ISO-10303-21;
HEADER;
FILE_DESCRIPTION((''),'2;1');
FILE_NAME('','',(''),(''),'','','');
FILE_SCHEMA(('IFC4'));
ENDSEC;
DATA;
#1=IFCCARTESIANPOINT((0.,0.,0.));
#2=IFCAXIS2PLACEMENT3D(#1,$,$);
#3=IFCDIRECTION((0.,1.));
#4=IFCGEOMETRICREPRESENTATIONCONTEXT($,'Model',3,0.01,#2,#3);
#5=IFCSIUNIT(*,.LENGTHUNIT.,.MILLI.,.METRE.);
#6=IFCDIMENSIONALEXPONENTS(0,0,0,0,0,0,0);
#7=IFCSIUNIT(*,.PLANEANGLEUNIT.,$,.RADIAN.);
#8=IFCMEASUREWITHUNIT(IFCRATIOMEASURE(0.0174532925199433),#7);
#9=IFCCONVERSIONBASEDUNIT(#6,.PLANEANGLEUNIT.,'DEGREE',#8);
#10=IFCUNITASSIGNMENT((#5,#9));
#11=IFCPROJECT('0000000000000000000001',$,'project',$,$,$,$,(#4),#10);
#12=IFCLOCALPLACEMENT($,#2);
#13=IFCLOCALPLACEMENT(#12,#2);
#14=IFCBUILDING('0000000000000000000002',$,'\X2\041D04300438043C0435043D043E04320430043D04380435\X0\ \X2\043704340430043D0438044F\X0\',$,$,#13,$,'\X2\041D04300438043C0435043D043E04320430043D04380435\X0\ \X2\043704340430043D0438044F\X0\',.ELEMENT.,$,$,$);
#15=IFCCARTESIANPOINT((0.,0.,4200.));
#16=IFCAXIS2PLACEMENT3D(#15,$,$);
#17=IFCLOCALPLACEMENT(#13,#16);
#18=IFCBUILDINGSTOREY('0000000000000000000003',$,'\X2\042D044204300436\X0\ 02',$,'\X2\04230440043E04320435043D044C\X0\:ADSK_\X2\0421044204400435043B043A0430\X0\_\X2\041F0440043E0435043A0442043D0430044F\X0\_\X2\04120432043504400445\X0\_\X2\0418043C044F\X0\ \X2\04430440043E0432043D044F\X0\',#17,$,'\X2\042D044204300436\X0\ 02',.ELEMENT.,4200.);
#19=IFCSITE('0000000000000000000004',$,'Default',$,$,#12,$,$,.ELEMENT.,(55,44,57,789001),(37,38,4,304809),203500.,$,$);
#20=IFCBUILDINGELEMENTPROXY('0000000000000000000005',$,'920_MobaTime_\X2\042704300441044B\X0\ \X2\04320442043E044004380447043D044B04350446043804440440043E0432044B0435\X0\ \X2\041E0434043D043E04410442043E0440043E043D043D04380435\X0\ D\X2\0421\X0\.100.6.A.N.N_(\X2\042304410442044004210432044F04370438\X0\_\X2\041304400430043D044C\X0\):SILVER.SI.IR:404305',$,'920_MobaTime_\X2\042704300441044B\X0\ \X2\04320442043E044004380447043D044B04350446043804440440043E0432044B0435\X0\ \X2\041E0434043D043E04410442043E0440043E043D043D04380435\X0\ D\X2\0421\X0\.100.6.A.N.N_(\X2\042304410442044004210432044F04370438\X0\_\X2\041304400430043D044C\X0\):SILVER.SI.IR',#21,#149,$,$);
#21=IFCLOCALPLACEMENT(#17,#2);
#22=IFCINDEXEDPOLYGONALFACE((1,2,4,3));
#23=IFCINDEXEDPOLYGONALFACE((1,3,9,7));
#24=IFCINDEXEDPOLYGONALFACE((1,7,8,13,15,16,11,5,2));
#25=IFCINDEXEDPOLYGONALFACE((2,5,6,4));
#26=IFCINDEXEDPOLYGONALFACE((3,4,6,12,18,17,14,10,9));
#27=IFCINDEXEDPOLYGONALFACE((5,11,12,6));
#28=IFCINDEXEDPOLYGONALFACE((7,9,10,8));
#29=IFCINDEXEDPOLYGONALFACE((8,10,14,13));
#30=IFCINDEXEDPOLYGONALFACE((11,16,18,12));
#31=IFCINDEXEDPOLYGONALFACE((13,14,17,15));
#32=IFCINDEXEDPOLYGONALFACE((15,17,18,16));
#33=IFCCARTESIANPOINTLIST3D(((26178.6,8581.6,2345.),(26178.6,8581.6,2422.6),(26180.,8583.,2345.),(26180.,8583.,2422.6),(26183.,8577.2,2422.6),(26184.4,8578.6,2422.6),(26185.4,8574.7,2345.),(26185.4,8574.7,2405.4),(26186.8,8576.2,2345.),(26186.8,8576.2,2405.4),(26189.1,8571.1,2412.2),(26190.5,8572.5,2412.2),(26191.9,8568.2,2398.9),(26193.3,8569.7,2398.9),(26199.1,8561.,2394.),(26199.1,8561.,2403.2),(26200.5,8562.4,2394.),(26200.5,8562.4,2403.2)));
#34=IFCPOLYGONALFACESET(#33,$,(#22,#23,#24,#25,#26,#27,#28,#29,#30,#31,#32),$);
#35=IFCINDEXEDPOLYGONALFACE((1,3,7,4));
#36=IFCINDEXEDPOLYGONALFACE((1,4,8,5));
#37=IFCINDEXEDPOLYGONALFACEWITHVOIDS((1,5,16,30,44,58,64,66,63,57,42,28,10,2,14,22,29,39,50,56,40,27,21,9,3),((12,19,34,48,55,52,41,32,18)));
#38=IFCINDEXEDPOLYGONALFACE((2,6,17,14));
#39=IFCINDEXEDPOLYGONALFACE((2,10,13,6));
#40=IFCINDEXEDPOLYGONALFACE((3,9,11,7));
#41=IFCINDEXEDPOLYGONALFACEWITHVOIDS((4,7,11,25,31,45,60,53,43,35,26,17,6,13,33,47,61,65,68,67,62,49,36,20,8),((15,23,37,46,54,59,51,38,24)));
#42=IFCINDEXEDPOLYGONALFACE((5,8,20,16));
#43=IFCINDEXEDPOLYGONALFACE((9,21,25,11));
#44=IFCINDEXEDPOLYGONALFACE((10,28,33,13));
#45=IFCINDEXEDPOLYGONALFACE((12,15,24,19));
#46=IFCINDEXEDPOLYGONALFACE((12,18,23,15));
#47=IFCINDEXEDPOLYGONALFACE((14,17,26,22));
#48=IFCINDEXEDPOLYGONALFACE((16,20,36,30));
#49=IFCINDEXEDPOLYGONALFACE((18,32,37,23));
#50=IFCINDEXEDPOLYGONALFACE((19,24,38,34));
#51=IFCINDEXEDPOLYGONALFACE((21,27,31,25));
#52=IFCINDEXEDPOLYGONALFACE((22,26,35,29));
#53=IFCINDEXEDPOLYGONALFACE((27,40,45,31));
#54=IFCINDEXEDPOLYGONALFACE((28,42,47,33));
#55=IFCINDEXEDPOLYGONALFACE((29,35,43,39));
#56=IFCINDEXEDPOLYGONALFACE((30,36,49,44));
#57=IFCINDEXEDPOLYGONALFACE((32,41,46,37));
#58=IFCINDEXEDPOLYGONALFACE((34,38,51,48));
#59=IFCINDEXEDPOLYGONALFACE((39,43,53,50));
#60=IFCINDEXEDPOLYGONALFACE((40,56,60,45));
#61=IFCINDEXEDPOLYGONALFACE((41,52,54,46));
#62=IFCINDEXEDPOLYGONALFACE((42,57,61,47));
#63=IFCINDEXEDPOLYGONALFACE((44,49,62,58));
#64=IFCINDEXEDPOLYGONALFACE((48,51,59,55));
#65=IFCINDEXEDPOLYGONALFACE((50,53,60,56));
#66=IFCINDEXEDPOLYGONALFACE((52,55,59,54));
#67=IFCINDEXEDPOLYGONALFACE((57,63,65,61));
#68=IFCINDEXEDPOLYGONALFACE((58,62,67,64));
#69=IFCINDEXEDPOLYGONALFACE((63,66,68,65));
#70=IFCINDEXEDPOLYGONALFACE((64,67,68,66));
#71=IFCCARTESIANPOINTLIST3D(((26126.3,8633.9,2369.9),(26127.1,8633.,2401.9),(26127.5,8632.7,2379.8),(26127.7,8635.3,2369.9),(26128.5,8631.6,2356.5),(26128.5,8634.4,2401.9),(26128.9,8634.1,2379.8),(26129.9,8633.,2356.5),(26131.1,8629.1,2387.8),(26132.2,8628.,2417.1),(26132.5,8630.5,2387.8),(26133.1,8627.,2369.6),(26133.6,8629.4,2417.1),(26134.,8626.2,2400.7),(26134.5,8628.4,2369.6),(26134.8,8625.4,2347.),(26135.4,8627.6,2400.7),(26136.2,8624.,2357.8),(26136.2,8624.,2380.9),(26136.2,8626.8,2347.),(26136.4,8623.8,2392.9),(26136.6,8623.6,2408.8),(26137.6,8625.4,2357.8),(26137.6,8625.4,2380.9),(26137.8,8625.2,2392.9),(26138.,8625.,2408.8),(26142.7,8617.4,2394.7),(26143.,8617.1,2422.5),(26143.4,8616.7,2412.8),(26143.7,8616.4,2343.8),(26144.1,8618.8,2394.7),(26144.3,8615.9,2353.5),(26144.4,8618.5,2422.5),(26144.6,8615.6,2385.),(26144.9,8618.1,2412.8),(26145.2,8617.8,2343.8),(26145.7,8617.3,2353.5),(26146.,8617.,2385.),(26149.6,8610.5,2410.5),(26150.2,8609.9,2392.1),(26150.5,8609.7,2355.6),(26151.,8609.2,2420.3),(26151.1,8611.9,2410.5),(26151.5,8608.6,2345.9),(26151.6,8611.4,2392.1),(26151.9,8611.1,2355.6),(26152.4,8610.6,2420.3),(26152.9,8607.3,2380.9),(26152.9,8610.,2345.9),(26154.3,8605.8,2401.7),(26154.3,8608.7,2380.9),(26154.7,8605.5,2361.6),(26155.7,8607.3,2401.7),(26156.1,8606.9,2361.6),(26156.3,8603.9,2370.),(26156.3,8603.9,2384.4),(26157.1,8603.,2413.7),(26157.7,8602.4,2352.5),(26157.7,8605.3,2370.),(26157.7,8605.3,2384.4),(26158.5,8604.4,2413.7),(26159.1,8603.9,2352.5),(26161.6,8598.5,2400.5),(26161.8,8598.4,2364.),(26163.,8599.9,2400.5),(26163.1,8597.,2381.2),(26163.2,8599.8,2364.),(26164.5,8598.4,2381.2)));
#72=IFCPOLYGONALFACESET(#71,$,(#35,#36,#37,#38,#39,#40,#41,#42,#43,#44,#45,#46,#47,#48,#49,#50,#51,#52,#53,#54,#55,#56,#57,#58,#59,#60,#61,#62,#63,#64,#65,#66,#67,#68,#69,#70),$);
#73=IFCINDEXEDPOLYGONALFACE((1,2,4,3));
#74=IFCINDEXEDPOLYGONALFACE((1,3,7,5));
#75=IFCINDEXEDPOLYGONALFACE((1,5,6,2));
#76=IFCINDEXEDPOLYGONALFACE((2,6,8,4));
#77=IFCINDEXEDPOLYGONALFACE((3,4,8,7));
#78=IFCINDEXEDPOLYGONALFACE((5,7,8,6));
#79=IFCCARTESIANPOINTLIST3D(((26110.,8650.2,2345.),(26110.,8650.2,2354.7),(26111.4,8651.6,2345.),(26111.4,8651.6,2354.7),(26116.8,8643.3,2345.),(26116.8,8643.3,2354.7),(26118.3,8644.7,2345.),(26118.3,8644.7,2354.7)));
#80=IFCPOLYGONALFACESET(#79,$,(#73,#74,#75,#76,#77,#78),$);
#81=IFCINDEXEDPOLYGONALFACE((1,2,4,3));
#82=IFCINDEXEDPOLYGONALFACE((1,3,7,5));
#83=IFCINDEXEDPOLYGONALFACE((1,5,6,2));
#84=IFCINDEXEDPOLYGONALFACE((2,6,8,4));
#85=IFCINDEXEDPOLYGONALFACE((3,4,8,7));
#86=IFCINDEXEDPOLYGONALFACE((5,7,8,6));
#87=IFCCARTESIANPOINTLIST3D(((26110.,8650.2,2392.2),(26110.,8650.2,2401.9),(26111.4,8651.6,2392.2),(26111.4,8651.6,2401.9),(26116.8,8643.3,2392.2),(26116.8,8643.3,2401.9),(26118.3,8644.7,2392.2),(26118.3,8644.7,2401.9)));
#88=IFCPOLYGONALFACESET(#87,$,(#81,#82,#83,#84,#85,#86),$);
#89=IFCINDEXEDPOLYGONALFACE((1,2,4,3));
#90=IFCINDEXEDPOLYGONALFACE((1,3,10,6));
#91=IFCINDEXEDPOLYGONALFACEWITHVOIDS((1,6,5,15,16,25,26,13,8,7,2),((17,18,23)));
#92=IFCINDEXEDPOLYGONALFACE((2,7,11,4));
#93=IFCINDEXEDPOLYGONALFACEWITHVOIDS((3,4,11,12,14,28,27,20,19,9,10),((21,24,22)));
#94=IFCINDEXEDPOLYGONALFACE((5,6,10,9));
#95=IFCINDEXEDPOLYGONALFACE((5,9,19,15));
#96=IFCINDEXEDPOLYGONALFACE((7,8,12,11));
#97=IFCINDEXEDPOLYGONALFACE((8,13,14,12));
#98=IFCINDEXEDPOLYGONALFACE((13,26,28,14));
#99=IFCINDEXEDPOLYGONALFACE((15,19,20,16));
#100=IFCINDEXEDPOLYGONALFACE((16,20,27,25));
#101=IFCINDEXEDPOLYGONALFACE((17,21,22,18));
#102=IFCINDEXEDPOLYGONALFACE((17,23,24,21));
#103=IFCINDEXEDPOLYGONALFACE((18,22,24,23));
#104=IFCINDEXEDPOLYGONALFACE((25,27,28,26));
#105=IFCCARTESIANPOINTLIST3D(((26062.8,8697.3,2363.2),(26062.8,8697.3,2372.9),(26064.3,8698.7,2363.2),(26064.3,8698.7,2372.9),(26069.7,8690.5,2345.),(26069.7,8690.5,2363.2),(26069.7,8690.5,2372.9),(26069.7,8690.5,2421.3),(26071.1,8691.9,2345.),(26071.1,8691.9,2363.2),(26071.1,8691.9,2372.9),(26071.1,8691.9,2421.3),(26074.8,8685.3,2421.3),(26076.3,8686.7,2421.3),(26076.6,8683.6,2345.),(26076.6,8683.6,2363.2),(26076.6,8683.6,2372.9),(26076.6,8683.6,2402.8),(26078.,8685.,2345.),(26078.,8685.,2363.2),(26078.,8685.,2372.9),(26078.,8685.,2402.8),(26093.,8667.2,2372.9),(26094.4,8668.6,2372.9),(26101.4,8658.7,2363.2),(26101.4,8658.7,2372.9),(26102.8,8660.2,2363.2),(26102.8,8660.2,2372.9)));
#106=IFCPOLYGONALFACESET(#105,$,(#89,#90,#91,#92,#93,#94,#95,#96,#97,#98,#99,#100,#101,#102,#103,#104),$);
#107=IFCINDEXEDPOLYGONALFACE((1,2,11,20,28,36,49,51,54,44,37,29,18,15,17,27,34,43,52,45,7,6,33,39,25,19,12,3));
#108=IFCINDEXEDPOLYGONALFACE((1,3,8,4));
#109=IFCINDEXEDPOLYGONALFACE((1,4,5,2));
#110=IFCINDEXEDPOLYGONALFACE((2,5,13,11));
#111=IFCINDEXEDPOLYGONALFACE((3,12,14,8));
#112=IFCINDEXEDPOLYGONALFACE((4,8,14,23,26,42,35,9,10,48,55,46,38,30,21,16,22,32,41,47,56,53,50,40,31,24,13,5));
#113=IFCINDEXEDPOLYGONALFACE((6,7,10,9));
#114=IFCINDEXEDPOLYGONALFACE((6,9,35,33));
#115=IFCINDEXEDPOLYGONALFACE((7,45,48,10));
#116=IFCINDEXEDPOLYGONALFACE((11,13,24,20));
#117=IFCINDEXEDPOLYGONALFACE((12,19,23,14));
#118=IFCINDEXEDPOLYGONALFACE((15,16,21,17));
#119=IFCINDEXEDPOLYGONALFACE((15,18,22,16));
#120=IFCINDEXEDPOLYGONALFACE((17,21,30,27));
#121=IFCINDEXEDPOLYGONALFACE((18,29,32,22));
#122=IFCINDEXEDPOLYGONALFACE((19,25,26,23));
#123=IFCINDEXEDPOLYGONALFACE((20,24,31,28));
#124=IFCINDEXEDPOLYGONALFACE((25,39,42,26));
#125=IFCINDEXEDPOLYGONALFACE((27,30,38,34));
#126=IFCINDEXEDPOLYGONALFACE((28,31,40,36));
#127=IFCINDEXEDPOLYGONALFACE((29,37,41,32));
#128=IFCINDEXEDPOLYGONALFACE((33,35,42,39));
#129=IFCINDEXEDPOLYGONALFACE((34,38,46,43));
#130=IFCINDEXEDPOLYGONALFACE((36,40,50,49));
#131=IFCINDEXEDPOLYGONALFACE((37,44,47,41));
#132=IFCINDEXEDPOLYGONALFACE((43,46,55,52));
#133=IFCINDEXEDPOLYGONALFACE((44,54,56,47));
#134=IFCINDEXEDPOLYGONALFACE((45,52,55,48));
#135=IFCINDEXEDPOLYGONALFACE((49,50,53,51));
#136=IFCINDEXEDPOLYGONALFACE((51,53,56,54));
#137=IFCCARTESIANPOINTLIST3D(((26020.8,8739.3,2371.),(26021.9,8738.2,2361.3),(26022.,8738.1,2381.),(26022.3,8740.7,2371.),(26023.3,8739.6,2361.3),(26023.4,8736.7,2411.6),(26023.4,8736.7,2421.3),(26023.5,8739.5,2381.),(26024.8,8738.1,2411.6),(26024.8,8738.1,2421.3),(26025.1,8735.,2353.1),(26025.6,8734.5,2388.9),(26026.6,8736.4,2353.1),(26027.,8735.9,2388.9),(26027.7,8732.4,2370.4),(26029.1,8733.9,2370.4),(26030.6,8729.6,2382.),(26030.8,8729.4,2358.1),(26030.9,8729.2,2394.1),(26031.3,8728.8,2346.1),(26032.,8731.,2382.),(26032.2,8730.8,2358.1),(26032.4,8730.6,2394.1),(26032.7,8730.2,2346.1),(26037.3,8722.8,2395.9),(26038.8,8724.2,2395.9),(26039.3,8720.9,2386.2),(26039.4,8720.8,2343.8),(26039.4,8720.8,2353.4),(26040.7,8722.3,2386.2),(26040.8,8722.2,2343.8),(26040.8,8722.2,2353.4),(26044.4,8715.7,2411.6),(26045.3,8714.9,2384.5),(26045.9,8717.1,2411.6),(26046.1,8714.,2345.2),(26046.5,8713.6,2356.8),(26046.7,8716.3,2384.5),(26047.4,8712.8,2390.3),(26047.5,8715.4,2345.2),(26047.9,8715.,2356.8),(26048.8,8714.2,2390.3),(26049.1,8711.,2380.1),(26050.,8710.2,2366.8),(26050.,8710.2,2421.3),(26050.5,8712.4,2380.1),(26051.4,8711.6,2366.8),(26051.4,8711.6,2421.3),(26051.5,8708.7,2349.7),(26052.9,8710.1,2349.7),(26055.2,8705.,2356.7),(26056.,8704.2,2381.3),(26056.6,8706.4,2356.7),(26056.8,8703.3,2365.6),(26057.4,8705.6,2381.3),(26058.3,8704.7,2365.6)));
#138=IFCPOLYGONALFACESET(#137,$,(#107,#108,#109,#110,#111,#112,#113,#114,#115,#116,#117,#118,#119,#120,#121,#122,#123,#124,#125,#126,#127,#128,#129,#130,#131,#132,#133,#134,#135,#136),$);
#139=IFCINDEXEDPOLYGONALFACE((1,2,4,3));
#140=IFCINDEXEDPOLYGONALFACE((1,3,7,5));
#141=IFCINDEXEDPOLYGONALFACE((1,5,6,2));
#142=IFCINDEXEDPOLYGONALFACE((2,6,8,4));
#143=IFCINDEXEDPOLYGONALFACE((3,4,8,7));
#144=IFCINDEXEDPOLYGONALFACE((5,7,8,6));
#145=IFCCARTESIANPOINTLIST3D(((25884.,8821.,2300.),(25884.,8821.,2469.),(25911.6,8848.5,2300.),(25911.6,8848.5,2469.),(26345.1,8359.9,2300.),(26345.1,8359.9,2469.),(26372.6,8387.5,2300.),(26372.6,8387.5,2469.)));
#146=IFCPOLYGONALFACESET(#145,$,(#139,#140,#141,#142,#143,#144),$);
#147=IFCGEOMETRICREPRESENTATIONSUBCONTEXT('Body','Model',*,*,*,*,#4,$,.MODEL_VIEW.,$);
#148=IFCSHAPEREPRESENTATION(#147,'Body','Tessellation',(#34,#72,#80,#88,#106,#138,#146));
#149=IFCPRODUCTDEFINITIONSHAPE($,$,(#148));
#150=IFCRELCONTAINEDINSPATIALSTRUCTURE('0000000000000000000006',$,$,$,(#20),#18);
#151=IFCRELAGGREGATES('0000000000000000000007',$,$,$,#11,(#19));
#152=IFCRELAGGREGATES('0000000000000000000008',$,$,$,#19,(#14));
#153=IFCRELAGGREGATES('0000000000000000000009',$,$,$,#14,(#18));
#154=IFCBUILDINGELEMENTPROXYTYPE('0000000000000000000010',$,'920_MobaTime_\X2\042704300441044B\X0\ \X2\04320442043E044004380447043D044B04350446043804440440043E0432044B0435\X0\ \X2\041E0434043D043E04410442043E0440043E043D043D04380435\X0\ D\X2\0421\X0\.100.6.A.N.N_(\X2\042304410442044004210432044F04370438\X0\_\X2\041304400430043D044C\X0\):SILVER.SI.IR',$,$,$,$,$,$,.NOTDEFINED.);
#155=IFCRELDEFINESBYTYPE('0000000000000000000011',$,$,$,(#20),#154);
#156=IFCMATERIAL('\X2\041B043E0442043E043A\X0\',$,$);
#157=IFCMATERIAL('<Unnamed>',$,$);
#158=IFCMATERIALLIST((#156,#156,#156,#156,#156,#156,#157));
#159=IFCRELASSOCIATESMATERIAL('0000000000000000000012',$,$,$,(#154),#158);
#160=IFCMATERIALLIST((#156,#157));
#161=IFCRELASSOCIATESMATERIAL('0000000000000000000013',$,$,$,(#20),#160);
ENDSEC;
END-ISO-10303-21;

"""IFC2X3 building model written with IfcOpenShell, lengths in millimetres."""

from ifc_helpers import new_model, entity, si_unit, converted_unit, direction, frame, origin, origin_2d_with_axis, place, context, subcontext, project, spatial, polyline, rectangle, outline, extrude, source, transform, mapped, material, material_list, type_object, type_shapes, element, save


model = new_model("IFC2X3")

# Units and contexts
model_context = context("Model", 3, precision=0.01, world=origin(), true_north=direction((0.0, 1.0)))
body_context = subcontext(model_context, "Body", "Model", "MODEL_VIEW")
ifc_project = project(units=[si_unit("LENGTHUNIT", "METRE", prefix="MILLI"), converted_unit("PLANEANGLEUNIT", "DEGREE", entity("IfcRatioMeasure", 0.0174532925199433), si_unit("PLANEANGLEUNIT", "RADIAN"), dimensions=[0, 0, 0, 0, 0, 0, 0])], contexts=[model_context])

# Site, building, storey
site_placement = place(None, origin())
site = spatial("IfcSite", under=ifc_project, at=site_placement, Name="Default", CompositionType="ELEMENT", RefLatitude=(55, 44, 57, 789001), RefLongitude=(37, 38, 4, 304809), RefElevation=203500.0)
building_placement = place(site_placement, origin())
building = spatial("IfcBuilding", under=site, at=building_placement, Name="Наименование здания", LongName="Наименование здания", CompositionType="ELEMENT")
storey_placement = place(building_placement, frame((0.0, 0.0, 4200.0)))
storey = spatial("IfcBuildingStorey", under=building, at=storey_placement, Name="Этаж 02", ObjectType="Уровень:ADSK_Стрелка_Проектная_Вверх_Имя уровня", LongName="Этаж 02", CompositionType="ELEMENT", Elevation=4200.0)

# Building element proxy
ifc_material_1 = material(Name="Лоток")
ifc_material_2 = material(Name="<Unnamed>")
ifc_material_list_1 = material_list([ifc_material_1, ifc_material_2])
ifc_material_list_2 = material_list([ifc_material_1, ifc_material_1, ifc_material_1, ifc_material_1, ifc_material_1, ifc_material_1, ifc_material_2])
building_element_proxy_type_1 = type_object("IfcBuildingElementProxyType", Name="920_MobaTime_Часы вторичныецифровые Односторонние DС.100.6.A.N.N_(УстрСвязи_Грань):SILVER.SI.IR", PredefinedType="NOTDEFINED", material=ifc_material_list_2)
shared_shape_1 = source(origin(), body_context, "Body", "SweptSolid", [
    extrude(outline(polyline([(-49.3, -13.1), (28.2, -13.1), (28.2, -6.8), (17.9, 1.8), (8.8, 16.0), (-0.3, 16.0), (4.6, 5.8), (11.1, -3.4), (-49.3, -3.4), (-49.3, -13.1)])), frame((-64.6, 9.8, 39.0), z_axis=(0.0, 0.0, 1.0), x_axis=(0.0, 1.0, 0.0)), (0.0, 0.0, 1.0), 2.0),
    extrude(outline(polyline([(2.2, -27.6), (19.0, -27.6), (30.5, -16.1), (33.3, -4.9), (31.0, 5.8), (21.8, 17.2), (5.2, 27.3), (-11.1, 33.0), (-24.0, 32.7), (-33.6, 27.6), (-40.3, 18.6), (-42.8, 5.7), (-38.0, -6.3), (-27.2, -14.9), (-17.5, -17.7), (-8.2, -16.4), (-0.3, -11.9), (5.1, -4.5), (7.3, 6.2), (4.0, 17.2), (18.4, 7.3), (23.6, -2.4), (22.0, -11.4), (14.2, -18.4), (5.3, -18.3), (2.2, -27.6)]), holes=[polyline([(-9.0, 23.3), (-1.3, 14.3), (-2.5, 2.0), (-11.4, -7.0), (-23.4, -6.0), (-32.2, 2.9), (-31.2, 15.1), (-25.6, 22.1), (-17.5, 24.9), (-9.0, 23.3)])]), frame((-2.7, 3.6, 39.0), z_axis=(0.0, 0.0, 1.0), x_axis=(-0.427649, 0.903945, 0.0)), (0.0, 0.0, 1.0), 2.0),
    extrude(rectangle(XDim=9.7, YDim=9.7, at=origin_2d_with_axis()), frame((40.6, -34.7, 39.0)), (0.0, 0.0, 1.0), 2.0),
    extrude(rectangle(XDim=9.7, YDim=9.7, at=origin_2d_with_axis()), frame((40.6, 12.6, 39.0)), (0.0, 0.0, 1.0), 2.0),
    extrude(outline(polyline([(-0.9, -28.1), (8.8, -28.1), (8.8, -9.9), (18.5, -9.9), (18.5, -0.2), (8.8, -0.2), (8.8, 48.3), (1.5, 48.3), (-36.0, -0.2), (-36.0, -9.9), (-0.9, -9.9), (-0.9, -28.1)]), holes=[polyline([(-0.9, -0.2), (-24.1, -0.2), (-0.9, 29.7), (-0.9, -0.2)])]), frame((93.6, -11.4, 39.0)), (0.0, 0.0, 1.0), 2.0),
    extrude(outline(polyline([(3.3, -28.3), (12.5, -28.3), (20.5, -25.0), (26.8, -18.9), (30.7, -10.0), (31.4, 1.6), (26.9, 11.8), (20.1, 18.4), (11.1, 22.3), (1.0, 23.3), (-7.9, 20.4), (-14.9, 14.5), (-18.9, 6.2), (-17.1, -9.0), (-36.7, 0.5), (-29.1, 29.2), (-38.5, 31.7), (-48.1, -4.6), (-11.6, -23.1), (-8.0, -14.0), (-10.8, -7.6), (-10.2, 1.1), (-3.0, 11.8), (9.2, 12.8), (20.0, 5.5), (21.4, -7.5), (15.5, -16.4), (4.6, -18.6), (3.3, -28.3)])), frame((147.1, -8.5, 39.0), z_axis=(0.0, 0.0, 1.0), x_axis=(0.256974, -0.966418, 0.0)), (0.0, 0.0, 1.0), 2.0),
    extrude(rectangle(XDim=652.0, YDim=169.0, at=origin_2d_with_axis()), frame((0.0, 0.0, 0.0), z_axis=(0.0, 0.0, 1.0), x_axis=(-1.0, 0.0, 0.0)), (0.0, 0.0, 1.0), 39.0),
])
type_shapes(building_element_proxy_type_1, [shared_shape_1])
for number, where, z_axis, x_axis, name in (
    (1, (26114.5, 8590.5, 2384.5), (0.707107, 0.707107, 0.0), (-0.707107, 0.707107, 0.0), "920_MobaTime_Часы вторичныецифровые Односторонние DС.100.6.A.N.N_(УстрСвязи_Грань):SILVER.SI.IR:404305"),
):
    element("IfcBuildingElementProxy", number, at=place(storey_placement, frame(where, z_axis=z_axis, x_axis=x_axis)), inside=storey, type_object=building_element_proxy_type_1, material=ifc_material_list_1, Name=name, ObjectType="920_MobaTime_Часы вторичныецифровые Односторонние DС.100.6.A.N.N_(УстрСвязи_Грань):SILVER.SI.IR", context=body_context, shape_type="MappedRepresentation", body=[
        mapped(shared_shape_1, transform((0.0, 0.0, 0.0), scale=1.0)),
    ])

save(model, "model.ifc")
